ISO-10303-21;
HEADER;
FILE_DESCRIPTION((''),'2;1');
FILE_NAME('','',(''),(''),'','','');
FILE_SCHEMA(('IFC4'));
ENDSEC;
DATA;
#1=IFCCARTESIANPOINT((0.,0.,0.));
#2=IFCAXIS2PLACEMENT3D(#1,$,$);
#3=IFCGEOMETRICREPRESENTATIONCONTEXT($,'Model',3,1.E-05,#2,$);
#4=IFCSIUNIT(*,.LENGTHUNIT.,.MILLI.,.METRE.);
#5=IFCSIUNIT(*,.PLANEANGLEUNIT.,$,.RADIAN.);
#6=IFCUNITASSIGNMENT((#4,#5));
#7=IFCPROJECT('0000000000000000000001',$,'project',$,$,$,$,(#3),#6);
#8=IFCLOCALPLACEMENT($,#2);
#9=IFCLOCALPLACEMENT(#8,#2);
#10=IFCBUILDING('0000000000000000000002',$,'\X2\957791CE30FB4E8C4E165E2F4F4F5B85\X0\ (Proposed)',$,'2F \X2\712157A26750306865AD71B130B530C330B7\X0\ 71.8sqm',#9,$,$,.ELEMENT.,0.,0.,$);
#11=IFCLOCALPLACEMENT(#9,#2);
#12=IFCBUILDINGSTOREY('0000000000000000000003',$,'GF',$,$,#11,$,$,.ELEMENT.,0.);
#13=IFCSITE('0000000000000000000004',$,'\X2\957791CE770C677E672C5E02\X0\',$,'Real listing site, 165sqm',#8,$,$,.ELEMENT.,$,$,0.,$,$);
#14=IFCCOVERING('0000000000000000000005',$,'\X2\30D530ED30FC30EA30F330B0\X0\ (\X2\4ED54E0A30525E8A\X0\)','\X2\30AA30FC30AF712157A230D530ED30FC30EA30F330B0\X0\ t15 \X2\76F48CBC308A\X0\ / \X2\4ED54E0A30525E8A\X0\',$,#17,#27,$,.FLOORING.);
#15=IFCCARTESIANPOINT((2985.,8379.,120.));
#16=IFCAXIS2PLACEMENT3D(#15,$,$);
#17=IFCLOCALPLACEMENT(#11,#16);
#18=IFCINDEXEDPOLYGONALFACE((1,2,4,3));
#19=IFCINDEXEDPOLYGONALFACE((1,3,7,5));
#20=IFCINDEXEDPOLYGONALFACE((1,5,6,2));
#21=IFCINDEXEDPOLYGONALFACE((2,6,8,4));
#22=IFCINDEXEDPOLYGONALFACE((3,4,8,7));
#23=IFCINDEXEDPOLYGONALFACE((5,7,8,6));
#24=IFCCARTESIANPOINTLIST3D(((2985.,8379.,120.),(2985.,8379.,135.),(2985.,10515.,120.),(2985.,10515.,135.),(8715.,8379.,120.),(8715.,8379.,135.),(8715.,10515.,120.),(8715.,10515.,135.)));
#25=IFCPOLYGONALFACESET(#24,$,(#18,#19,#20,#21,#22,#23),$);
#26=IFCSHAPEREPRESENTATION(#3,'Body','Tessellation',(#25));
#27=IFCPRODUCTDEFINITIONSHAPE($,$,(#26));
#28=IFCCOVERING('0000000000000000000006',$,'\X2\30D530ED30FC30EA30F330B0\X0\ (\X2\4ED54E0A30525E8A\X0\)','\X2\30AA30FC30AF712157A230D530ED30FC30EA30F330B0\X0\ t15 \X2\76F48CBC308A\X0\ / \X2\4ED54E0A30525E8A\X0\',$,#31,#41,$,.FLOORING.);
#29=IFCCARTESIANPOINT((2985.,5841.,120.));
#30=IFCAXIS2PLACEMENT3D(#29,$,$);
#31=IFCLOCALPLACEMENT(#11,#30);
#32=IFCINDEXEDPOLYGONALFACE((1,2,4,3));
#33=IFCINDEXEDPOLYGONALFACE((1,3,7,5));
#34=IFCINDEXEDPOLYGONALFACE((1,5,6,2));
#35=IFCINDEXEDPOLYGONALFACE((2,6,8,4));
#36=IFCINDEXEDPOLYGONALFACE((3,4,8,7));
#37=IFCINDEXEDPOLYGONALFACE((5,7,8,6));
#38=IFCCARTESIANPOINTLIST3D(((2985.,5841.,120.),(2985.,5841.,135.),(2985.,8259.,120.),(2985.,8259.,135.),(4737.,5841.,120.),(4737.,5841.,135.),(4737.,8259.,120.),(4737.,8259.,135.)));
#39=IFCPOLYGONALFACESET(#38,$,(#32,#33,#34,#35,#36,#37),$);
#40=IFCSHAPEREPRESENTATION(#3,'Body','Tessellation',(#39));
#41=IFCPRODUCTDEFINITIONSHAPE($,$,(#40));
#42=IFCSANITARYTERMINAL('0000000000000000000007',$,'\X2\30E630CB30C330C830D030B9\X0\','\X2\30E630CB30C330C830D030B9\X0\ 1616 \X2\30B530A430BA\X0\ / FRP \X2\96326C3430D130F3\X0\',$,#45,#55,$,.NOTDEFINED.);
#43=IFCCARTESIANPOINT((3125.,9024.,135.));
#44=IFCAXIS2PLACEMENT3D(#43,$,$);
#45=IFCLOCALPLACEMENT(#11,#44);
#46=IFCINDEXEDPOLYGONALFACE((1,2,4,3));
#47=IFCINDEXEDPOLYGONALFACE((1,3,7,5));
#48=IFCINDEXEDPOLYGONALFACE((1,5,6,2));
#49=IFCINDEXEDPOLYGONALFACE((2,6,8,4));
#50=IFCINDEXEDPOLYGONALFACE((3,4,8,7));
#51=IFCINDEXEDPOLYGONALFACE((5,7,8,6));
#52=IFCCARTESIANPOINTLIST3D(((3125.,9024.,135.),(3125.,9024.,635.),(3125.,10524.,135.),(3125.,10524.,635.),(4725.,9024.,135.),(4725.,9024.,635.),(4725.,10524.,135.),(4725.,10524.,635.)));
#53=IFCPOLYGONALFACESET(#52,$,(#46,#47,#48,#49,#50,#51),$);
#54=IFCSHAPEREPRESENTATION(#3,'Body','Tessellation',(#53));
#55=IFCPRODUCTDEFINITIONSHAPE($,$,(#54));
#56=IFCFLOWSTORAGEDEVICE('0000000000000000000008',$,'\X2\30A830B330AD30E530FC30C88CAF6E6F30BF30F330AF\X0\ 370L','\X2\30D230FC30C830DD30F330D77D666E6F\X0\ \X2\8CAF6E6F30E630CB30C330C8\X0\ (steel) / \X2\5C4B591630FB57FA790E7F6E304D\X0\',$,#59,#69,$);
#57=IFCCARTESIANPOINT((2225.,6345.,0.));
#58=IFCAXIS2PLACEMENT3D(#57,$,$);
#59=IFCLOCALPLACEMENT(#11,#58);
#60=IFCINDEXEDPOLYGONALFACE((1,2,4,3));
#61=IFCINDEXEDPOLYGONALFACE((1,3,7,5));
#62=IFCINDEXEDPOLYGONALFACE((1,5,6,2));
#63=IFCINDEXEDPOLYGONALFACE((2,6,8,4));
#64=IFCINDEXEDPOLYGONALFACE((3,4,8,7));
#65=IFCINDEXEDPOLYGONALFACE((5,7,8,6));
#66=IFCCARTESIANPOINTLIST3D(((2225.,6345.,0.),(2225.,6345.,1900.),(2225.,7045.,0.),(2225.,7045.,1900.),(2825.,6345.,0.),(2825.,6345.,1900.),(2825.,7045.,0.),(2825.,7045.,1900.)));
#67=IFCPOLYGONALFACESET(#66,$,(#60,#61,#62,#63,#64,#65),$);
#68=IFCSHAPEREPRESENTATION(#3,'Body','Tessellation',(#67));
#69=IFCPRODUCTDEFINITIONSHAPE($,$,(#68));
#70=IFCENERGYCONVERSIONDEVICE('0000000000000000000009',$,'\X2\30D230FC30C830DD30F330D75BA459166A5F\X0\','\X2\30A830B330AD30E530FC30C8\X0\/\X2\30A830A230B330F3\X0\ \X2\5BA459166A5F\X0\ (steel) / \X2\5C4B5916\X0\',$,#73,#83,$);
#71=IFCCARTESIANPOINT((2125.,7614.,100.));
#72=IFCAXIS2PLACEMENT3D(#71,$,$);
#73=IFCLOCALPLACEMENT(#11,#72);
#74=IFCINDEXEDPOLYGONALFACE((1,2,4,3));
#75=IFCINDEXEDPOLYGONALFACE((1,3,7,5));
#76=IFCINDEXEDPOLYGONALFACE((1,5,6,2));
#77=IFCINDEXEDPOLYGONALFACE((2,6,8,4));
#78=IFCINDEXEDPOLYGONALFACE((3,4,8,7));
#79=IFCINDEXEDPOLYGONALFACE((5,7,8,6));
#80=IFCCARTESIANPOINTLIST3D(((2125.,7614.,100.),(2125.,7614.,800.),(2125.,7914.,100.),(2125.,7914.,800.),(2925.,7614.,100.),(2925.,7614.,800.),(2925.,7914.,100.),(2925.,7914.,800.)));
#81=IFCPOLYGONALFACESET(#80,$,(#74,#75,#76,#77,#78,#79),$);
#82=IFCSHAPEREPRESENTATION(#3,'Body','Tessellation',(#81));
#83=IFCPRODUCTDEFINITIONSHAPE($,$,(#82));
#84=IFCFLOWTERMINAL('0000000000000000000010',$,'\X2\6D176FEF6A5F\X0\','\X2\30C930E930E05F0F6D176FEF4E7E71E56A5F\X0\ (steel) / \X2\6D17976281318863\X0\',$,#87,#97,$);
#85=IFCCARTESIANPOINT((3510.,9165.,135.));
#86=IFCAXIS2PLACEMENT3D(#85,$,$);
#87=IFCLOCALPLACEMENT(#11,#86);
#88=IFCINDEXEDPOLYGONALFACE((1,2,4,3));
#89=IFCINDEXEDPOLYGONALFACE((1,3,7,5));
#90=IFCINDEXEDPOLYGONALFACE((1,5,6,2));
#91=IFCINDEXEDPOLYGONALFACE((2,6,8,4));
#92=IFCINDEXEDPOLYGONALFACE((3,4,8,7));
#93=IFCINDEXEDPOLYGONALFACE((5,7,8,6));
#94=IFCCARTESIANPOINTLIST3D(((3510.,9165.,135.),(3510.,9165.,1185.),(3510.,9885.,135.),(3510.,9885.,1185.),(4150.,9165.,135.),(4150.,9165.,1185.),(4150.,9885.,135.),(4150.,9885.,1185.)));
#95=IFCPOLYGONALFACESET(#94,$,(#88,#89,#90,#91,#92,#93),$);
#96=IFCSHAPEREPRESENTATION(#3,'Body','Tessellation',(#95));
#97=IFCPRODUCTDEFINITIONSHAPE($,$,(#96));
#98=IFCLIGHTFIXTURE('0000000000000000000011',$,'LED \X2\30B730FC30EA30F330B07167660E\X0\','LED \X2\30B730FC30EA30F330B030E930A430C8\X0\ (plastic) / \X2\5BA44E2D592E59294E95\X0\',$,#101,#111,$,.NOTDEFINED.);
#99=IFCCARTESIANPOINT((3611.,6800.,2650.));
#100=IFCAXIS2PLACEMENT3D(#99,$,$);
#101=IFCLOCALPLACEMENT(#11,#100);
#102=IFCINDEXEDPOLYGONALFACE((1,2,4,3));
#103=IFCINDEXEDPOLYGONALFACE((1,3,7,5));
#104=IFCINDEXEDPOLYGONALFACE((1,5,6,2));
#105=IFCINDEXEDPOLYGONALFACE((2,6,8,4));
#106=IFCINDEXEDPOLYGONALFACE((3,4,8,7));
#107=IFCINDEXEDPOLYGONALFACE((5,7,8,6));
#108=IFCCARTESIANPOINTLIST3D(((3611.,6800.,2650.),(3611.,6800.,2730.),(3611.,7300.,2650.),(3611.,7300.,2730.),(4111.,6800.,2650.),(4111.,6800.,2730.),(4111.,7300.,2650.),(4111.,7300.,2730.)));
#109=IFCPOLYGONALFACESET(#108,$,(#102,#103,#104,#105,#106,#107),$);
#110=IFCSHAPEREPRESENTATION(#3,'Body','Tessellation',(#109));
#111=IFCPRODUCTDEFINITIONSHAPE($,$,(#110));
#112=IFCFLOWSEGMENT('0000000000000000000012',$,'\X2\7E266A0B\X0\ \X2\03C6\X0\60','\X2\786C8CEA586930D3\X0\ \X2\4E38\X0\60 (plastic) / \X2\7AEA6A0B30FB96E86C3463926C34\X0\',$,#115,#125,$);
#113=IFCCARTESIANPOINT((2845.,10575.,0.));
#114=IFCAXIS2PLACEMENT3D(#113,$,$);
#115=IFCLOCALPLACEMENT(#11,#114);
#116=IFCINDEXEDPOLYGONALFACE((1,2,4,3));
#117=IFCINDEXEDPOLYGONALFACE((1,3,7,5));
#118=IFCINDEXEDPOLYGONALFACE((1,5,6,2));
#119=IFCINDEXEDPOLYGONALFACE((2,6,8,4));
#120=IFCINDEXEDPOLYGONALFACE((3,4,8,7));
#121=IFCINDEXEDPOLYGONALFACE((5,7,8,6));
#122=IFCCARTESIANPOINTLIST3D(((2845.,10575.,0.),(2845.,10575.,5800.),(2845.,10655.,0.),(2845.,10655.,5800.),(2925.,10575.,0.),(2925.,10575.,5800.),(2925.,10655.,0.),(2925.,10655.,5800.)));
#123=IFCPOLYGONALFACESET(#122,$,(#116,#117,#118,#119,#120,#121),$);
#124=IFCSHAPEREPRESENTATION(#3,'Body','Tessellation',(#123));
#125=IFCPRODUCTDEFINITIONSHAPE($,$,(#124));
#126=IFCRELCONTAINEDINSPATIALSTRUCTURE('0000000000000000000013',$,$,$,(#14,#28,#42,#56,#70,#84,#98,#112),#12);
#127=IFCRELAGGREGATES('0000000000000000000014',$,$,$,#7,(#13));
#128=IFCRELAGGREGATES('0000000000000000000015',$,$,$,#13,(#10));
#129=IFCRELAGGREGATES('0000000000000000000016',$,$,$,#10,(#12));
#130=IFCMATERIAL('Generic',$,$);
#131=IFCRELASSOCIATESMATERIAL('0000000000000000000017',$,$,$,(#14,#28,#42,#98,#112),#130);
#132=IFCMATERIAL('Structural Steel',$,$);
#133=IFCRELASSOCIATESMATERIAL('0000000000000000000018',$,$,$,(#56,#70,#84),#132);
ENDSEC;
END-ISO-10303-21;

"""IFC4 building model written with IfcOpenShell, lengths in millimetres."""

from ifc_helpers import new_model, si_unit, frame, frame_2d, origin, place, context, project, spatial, rectangle, extrude, material, element, save


model = new_model("IFC4")

# Units and contexts
model_context = context("Model", 3, precision=1e-05, world=origin())
ifc_project = project(units=[si_unit("LENGTHUNIT", "METRE", prefix="MILLI"), si_unit("PLANEANGLEUNIT", "RADIAN")], contexts=[model_context])

# Site, building, storey
site_placement = place(None, origin())
site = spatial("IfcSite", under=ifc_project, at=site_placement, Name="長野県松本市", ObjectType="Real listing site, 165sqm", CompositionType="ELEMENT", RefElevation=0.0)
building_placement = place(site_placement, origin())
building = spatial("IfcBuilding", under=site, at=building_placement, Name="長野・二世帯住宅 (Proposed)", ObjectType="2F 無垢材と断熱サッシ 71.8sqm", CompositionType="ELEMENT", ElevationOfRefHeight=0.0, ElevationOfTerrain=0.0)
storey_placement = place(building_placement, origin())
storey = spatial("IfcBuildingStorey", under=building, at=storey_placement, Name="GF", CompositionType="ELEMENT", Elevation=0.0)

# Coverings
ifc_material_1 = material(Name="Generic")
covering_1_placement = place(storey_placement, frame((2985.0, 8379.0, 120.0)))
element("IfcCovering", 1, at=covering_1_placement, inside=storey, material=ifc_material_1, Name="フローリング (仕上げ床)", Description="オーク無垢フローリング t15 直貼り / 仕上げ床", PredefinedType="FLOORING", context=model_context, shape_type="SweptSolid", body=[
    extrude(rectangle(XDim=5730.0, YDim=2136.0, at=frame_2d((2865.0, 1068.0))), frame((2985.0, 8379.0, 120.0)), (0.0, 0.0, 1.0), 15.0),
])
covering_2_placement = place(storey_placement, frame((2985.0, 5841.0, 120.0)))
element("IfcCovering", 2, at=covering_2_placement, inside=storey, material=ifc_material_1, Name="フローリング (仕上げ床)", Description="オーク無垢フローリング t15 直貼り / 仕上げ床", PredefinedType="FLOORING", context=model_context, shape_type="SweptSolid", body=[
    extrude(rectangle(XDim=1752.0, YDim=2418.0, at=frame_2d((876.0, 1209.0))), frame((2985.0, 5841.0, 120.0)), (0.0, 0.0, 1.0), 15.0),
])

# Sanitary terminal
sanitary_terminal_placement = place(storey_placement, frame((3125.0, 9024.0, 135.0)))
element("IfcSanitaryTerminal", 3, at=sanitary_terminal_placement, inside=storey, material=ifc_material_1, Name="ユニットバス", Description="ユニットバス 1616 サイズ / FRP 防水パン", PredefinedType="NOTDEFINED", context=model_context, shape_type="SweptSolid", body=[
    extrude(rectangle(XDim=1600.0, YDim=1500.0, at=frame_2d((800.0, 750.0))), frame((3125.0, 9024.0, 135.0)), (0.0, 0.0, 1.0), 500.0),
])

# Flow storage device
ifc_material_2 = material(Name="Structural Steel")
flow_storage_device_placement = place(storey_placement, frame((2225.0, 6345.0, 0.0)))
element("IfcFlowStorageDevice", 4, at=flow_storage_device_placement, inside=storey, material=ifc_material_2, Name="エコキュート貯湯タンク 370L", Description="ヒートポンプ給湯 貯湯ユニット (steel) / 屋外・基礎置き", context=model_context, shape_type="SweptSolid", body=[
    extrude(rectangle(XDim=600.0, YDim=700.0, at=frame_2d((300.0, 350.0))), frame((2225.0, 6345.0, 0.0)), (0.0, 0.0, 1.0), 1900.0),
])

# Energy conversion device
energy_conversion_device_placement = place(storey_placement, frame((2125.0, 7614.0, 100.0)))
element("IfcEnergyConversionDevice", 5, at=energy_conversion_device_placement, inside=storey, material=ifc_material_2, Name="ヒートポンプ室外機", Description="エコキュート/エアコン 室外機 (steel) / 屋外", context=model_context, shape_type="SweptSolid", body=[
    extrude(rectangle(XDim=800.0, YDim=300.0, at=frame_2d((400.0, 150.0))), frame((2125.0, 7614.0, 100.0)), (0.0, 0.0, 1.0), 700.0),
])

# Flow terminal
flow_terminal_placement = place(storey_placement, frame((3510.0, 9165.0, 135.0)))
element("IfcFlowTerminal", 6, at=flow_terminal_placement, inside=storey, material=ifc_material_2, Name="洗濯機", Description="ドラム式洗濯乾燥機 (steel) / 洗面脱衣", context=model_context, shape_type="SweptSolid", body=[
    extrude(rectangle(XDim=640.0, YDim=720.0, at=frame_2d((320.0, 360.0))), frame((3510.0, 9165.0, 135.0)), (0.0, 0.0, 1.0), 1050.0),
])

# Light fixture
light_fixture_placement = place(storey_placement, frame((3611.0, 6800.0, 2650.0)))
element("IfcLightFixture", 7, at=light_fixture_placement, inside=storey, material=ifc_material_1, Name="LED シーリング照明", Description="LED シーリングライト (plastic) / 室中央天井", PredefinedType="NOTDEFINED", context=model_context, shape_type="SweptSolid", body=[
    extrude(rectangle(XDim=500.0, YDim=500.0, at=frame_2d((250.0, 250.0))), frame((3611.0, 6800.0, 2650.0)), (0.0, 0.0, 1.0), 80.0),
])

# Flow segment
flow_segment_placement = place(storey_placement, frame((2845.0, 10575.0, 0.0)))
element("IfcFlowSegment", 8, at=flow_segment_placement, inside=storey, material=ifc_material_1, Name="縦樋 φ60", Description="硬質塩ビ 丸60 (plastic) / 竪樋・雨水排水", context=model_context, shape_type="SweptSolid", body=[
    extrude(rectangle(XDim=80.0, YDim=80.0, at=frame_2d((40.0, 40.0))), frame((2845.0, 10575.0, 0.0)), (0.0, 0.0, 1.0), 5800.0),
])

save(model, "model.ifc")
